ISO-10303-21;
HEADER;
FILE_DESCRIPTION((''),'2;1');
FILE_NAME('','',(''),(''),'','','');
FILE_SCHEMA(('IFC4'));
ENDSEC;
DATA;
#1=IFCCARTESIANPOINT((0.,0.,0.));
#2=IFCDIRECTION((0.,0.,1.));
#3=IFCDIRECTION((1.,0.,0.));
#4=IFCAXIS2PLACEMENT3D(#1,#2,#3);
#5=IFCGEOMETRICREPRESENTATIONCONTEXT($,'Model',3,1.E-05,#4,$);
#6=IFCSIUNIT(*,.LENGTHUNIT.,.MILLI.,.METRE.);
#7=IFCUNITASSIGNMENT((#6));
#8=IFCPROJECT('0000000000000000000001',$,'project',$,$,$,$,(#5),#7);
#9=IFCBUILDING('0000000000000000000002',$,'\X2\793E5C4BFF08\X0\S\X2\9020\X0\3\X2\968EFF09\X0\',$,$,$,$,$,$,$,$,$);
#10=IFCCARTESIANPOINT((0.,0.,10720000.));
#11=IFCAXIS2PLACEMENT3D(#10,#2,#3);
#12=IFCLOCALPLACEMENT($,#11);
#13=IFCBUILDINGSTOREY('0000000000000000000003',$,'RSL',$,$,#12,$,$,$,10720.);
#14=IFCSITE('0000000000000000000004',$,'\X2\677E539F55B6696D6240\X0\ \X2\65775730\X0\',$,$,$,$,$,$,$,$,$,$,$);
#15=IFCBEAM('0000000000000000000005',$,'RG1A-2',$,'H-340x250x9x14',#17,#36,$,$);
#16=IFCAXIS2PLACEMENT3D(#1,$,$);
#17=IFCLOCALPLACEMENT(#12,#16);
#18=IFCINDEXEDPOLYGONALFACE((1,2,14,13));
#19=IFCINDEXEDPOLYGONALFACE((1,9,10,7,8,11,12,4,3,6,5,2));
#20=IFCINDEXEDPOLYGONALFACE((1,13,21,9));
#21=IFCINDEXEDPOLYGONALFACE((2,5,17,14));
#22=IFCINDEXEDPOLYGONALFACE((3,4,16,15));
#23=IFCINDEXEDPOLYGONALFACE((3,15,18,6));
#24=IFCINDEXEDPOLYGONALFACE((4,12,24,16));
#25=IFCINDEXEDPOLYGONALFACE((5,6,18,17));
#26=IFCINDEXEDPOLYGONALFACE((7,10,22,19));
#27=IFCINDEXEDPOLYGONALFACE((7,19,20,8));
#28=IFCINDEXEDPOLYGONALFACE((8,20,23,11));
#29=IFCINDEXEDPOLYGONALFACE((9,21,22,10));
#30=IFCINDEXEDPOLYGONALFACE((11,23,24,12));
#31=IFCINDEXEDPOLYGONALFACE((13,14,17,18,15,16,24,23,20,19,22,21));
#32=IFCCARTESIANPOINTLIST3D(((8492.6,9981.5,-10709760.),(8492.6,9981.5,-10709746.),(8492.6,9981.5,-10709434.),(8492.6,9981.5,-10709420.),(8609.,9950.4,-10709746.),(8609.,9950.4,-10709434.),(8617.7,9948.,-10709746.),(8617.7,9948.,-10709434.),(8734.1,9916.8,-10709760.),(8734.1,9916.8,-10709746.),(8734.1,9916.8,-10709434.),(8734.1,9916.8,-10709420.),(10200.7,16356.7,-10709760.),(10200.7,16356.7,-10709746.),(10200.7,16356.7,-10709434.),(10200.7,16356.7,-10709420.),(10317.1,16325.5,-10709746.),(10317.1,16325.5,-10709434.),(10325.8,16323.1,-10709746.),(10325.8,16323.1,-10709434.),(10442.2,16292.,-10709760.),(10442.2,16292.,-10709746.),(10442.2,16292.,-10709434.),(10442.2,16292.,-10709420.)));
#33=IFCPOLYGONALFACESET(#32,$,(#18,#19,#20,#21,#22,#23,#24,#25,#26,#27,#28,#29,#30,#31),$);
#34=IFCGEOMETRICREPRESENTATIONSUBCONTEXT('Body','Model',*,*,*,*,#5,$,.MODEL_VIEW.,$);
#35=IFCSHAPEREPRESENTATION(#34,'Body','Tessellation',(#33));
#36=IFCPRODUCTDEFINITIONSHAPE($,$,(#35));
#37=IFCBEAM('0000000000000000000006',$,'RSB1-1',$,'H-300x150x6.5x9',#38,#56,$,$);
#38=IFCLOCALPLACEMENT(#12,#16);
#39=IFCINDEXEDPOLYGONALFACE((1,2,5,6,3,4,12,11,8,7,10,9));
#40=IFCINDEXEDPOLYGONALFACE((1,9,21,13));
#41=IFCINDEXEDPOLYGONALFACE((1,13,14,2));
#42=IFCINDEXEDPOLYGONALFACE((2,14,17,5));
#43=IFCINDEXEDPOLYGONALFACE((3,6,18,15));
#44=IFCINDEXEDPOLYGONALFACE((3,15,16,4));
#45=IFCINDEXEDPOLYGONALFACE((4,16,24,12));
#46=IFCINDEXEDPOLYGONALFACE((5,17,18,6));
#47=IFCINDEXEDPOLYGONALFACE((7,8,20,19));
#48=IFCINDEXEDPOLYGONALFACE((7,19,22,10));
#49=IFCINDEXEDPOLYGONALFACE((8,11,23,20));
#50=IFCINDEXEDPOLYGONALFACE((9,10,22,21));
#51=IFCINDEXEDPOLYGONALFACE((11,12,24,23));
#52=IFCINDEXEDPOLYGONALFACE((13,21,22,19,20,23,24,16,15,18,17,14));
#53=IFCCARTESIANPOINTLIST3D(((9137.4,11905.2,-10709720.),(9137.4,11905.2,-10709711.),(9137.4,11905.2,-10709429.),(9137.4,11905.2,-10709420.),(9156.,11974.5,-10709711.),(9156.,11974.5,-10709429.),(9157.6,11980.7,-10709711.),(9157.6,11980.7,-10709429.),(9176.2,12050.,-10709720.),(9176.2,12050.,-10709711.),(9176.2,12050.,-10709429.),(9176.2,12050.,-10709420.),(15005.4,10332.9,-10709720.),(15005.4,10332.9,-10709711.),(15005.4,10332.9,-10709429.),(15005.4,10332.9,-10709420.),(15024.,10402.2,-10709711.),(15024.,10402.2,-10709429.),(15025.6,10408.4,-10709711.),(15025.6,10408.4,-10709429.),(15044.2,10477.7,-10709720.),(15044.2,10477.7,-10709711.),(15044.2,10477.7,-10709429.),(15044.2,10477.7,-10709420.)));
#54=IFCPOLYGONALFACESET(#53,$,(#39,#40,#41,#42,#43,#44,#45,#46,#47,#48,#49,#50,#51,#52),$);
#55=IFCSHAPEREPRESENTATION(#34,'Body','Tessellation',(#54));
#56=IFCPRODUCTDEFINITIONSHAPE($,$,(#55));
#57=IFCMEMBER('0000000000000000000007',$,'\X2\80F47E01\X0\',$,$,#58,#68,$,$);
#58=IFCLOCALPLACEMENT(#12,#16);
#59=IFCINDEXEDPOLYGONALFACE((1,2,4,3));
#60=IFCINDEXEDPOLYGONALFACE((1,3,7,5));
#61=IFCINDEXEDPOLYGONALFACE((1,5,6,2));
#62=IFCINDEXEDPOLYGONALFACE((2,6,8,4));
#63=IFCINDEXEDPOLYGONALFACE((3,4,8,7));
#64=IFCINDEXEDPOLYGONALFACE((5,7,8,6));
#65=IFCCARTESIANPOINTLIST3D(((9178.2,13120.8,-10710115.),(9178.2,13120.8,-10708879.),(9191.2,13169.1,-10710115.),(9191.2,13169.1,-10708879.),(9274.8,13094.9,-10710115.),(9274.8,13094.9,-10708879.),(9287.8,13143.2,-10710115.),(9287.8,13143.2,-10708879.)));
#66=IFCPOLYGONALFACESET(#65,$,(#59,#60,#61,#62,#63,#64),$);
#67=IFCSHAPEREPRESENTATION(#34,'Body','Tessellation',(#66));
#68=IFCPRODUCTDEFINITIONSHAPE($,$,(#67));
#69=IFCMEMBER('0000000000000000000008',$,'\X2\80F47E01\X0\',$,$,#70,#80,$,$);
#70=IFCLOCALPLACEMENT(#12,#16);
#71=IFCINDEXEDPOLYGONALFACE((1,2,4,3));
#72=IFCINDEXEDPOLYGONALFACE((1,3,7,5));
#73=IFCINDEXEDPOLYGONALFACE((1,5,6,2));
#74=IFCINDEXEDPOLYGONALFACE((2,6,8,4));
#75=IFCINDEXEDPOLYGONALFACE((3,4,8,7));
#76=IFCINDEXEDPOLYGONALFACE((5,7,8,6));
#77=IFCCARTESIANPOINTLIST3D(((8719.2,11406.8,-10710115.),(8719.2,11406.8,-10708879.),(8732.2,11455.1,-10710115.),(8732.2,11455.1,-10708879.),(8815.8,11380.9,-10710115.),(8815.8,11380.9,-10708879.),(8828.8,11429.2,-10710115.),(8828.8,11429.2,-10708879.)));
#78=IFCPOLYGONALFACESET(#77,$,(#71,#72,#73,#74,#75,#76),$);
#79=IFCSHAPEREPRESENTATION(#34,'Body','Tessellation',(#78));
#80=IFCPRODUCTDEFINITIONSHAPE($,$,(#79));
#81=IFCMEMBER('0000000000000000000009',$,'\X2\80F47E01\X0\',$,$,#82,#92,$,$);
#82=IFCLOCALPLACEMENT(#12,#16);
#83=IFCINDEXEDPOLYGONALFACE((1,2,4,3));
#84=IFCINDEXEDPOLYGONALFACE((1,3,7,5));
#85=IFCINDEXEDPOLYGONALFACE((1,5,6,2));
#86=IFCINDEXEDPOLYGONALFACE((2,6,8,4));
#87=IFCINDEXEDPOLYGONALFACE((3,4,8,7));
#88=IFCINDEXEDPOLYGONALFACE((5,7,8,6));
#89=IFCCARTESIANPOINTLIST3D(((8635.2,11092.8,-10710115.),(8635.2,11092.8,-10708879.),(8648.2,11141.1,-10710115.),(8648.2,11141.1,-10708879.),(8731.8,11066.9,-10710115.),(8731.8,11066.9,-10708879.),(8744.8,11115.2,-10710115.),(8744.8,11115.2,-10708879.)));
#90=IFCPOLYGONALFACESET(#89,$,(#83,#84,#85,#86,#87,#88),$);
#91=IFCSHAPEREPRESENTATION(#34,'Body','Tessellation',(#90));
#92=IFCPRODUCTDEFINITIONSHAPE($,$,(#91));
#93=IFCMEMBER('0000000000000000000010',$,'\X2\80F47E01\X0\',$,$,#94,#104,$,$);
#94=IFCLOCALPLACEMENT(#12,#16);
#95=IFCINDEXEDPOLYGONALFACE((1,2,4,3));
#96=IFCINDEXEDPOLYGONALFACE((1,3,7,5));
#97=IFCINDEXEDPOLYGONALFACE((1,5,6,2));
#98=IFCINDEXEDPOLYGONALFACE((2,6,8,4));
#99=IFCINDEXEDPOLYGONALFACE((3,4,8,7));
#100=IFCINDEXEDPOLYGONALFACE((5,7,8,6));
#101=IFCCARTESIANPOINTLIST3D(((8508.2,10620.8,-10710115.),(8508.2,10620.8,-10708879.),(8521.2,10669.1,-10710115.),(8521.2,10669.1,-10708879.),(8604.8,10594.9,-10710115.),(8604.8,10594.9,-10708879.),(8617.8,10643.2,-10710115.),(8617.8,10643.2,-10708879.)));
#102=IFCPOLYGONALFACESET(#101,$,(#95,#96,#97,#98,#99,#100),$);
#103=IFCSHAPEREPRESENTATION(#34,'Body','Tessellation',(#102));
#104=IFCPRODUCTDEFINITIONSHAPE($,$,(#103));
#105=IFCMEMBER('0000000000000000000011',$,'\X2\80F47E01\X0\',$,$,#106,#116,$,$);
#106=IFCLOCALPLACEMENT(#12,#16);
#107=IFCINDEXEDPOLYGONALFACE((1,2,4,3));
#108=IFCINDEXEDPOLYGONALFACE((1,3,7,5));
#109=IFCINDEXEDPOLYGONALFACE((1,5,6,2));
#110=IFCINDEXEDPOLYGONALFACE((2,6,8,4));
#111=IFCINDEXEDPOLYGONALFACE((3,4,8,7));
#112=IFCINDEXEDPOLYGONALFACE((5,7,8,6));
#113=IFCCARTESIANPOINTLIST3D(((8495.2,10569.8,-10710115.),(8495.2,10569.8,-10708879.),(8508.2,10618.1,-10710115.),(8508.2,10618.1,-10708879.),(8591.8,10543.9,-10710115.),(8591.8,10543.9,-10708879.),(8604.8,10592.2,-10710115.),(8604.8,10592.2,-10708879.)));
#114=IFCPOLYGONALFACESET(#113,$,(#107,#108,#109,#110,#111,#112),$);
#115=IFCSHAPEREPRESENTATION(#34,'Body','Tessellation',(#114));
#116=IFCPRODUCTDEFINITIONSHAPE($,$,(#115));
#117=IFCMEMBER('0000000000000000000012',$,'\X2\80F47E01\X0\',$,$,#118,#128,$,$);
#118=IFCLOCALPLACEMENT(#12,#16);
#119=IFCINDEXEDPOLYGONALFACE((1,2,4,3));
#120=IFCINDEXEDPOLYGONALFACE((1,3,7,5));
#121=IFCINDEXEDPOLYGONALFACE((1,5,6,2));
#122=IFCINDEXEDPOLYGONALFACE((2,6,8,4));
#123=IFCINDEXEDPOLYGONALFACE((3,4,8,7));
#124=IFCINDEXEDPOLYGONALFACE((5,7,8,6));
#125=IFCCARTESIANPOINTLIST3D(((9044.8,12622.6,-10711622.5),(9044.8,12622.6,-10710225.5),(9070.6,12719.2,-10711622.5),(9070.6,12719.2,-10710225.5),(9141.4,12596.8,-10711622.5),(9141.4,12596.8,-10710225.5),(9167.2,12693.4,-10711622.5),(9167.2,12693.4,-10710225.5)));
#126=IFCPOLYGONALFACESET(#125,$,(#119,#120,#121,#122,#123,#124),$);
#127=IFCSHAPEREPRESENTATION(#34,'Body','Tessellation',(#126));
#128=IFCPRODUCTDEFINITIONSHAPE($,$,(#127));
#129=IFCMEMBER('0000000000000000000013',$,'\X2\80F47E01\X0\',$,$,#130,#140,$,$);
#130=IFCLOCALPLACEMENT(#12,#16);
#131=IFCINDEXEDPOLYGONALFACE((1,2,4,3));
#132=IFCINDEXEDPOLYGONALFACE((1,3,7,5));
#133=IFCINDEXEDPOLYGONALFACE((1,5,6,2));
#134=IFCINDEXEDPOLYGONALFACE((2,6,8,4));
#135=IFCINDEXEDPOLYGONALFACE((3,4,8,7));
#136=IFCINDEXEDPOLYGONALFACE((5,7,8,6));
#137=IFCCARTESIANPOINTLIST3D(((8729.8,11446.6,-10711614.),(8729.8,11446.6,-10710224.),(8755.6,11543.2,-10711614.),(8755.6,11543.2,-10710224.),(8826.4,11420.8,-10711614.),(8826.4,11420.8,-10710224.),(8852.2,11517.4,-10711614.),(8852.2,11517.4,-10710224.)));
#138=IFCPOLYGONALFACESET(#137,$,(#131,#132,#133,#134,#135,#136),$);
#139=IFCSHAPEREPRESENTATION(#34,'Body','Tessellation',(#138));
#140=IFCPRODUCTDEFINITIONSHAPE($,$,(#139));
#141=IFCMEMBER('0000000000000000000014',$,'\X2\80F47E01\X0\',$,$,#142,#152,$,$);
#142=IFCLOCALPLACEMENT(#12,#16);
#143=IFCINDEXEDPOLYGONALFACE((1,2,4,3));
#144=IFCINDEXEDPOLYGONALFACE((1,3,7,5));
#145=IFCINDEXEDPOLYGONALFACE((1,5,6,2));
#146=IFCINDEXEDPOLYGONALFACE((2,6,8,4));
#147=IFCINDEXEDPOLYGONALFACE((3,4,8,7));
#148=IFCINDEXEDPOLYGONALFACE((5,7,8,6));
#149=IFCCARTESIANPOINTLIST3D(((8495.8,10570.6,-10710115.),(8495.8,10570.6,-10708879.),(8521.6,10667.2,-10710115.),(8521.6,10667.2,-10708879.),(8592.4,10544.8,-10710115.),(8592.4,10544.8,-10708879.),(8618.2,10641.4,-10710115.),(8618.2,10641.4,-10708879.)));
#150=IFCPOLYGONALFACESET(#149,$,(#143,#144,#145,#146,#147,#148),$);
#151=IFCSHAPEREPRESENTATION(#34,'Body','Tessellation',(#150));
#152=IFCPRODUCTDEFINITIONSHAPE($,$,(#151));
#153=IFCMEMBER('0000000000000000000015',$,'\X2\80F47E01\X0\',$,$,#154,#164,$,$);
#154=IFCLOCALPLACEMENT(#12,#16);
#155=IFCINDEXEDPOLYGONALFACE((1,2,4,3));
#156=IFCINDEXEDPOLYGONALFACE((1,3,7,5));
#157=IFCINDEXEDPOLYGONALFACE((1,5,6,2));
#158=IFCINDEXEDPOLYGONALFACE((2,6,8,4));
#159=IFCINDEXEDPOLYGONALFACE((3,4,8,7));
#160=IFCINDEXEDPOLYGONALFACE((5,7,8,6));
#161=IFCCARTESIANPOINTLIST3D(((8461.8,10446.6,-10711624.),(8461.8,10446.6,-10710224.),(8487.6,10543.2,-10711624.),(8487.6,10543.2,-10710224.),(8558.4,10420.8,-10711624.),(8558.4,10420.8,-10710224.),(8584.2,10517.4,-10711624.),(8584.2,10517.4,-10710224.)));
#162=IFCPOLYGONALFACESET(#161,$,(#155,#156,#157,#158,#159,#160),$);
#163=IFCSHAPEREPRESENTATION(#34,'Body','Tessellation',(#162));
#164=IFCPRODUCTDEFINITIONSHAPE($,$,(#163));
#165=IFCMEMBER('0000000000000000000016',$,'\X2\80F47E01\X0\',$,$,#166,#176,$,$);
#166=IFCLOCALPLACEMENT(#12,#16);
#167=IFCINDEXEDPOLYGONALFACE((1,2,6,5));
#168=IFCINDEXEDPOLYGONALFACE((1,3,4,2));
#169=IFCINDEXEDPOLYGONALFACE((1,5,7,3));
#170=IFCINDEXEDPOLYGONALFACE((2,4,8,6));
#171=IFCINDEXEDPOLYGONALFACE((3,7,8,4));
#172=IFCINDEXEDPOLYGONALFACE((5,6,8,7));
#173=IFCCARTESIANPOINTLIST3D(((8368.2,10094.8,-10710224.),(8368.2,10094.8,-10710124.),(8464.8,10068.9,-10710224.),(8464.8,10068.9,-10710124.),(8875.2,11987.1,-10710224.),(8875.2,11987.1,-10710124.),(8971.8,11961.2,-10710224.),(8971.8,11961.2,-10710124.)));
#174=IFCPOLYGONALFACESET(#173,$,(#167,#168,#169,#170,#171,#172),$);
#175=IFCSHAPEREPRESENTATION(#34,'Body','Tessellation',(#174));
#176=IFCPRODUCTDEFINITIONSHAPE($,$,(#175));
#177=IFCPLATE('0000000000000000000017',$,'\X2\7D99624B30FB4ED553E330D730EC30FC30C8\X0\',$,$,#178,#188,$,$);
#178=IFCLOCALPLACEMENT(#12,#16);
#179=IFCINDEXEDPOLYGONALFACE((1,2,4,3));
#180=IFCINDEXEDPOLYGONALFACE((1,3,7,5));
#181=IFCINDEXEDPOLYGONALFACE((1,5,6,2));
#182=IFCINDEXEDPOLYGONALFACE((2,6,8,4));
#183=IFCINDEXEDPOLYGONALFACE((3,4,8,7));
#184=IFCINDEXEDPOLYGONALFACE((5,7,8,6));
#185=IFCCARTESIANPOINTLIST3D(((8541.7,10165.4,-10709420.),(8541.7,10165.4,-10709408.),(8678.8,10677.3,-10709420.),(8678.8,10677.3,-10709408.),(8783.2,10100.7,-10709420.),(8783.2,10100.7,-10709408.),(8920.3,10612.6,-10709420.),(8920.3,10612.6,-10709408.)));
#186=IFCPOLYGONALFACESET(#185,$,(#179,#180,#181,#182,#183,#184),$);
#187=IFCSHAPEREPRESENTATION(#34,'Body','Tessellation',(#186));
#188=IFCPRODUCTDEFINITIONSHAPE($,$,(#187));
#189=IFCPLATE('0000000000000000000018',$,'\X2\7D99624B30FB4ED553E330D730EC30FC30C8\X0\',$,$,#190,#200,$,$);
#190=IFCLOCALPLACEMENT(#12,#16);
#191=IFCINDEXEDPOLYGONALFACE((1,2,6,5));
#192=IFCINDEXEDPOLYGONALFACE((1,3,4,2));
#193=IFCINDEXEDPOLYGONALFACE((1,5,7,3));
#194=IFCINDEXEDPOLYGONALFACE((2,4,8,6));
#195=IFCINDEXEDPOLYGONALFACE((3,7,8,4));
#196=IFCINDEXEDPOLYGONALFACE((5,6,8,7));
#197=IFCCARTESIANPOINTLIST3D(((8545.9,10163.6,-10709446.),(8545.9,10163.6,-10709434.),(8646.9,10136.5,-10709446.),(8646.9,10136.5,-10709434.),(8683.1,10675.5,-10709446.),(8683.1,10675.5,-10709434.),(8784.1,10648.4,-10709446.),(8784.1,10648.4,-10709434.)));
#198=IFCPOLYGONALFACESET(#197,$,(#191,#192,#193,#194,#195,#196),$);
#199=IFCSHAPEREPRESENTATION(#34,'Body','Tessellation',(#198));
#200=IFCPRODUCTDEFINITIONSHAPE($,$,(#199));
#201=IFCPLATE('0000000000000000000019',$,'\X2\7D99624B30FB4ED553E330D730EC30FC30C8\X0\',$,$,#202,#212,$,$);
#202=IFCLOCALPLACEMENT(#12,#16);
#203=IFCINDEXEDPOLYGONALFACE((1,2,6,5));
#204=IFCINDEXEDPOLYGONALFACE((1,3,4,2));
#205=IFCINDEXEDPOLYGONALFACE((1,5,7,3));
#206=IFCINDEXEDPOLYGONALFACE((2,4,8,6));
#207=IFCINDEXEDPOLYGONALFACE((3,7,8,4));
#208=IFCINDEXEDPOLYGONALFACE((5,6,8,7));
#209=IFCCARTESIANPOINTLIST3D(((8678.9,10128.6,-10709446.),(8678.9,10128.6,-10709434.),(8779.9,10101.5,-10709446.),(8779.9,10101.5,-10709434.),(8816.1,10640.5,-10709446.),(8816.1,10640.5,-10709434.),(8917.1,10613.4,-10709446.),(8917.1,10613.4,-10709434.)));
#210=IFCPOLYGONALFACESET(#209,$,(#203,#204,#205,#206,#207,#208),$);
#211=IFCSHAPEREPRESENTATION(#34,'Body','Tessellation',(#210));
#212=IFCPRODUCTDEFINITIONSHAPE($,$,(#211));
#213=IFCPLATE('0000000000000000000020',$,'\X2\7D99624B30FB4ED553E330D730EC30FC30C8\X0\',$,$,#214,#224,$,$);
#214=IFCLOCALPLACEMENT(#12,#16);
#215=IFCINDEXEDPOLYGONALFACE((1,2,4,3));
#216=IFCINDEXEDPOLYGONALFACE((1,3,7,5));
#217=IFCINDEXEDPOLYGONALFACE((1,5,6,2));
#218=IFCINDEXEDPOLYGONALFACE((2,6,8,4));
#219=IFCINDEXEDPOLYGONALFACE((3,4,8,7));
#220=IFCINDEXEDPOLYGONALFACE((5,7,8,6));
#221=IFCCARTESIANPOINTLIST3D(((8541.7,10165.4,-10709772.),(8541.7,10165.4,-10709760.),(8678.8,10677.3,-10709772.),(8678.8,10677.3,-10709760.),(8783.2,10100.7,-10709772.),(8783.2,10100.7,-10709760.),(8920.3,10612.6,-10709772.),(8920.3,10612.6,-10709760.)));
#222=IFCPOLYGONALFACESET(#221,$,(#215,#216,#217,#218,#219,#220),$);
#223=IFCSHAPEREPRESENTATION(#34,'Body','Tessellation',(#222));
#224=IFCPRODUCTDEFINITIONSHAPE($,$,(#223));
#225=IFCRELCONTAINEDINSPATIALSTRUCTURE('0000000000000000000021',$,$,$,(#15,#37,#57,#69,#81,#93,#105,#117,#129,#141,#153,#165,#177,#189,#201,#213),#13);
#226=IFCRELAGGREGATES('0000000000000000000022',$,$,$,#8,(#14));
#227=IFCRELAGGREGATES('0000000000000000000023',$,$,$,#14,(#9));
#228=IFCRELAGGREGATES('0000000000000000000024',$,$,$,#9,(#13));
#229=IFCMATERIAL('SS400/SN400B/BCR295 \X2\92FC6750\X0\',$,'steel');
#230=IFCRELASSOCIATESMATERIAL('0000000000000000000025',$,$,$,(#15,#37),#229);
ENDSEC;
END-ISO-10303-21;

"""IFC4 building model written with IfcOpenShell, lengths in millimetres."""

from ifc_helpers import new_model, si_unit, frame, origin, origin_with_axes, place, context, subcontext, project, spatial, rectangle, i_section, extrude, material, element, save


model = new_model("IFC4")

# Units and contexts
model_context = context("Model", 3, precision=1e-05, world=origin_with_axes())
body_context = subcontext(model_context, "Body", "Model", "MODEL_VIEW")
ifc_project = project(units=[si_unit("LENGTHUNIT", "METRE", prefix="MILLI")], contexts=[model_context])

# Site, building, storey
site = spatial("IfcSite", under=ifc_project, Name="松原営業所 敷地")
building = spatial("IfcBuilding", under=site, Name="社屋（S造3階）")
storey_placement = place(None, frame((0.0, 0.0, 10720000.0), z_axis=(0.0, 0.0, 1.0), x_axis=(1.0, 0.0, 0.0)))
storey = spatial("IfcBuildingStorey", under=building, at=storey_placement, Name="RSL", Elevation=10720.0)

# Beams
ifc_material = material(Name="SS400/SN400B/BCR295 鋼材", Category="steel")
beam_1_placement = place(storey_placement, frame((8613.3, 9949.2, -10709420.0), z_axis=(0.258812, 0.965928, 0.0), x_axis=(-0.965928, 0.258812, 0.0)))
element("IfcBeam", 1, at=beam_1_placement, inside=storey, material=ifc_material, Name="RG1A-2", ObjectType="H-340x250x9x14", context=body_context, shape_type="SweptSolid", body=[
    extrude(i_section(OverallWidth=250.0, OverallDepth=340.0, WebThickness=9.0, FlangeThickness=14.0), frame((0.0, -170.0, 0.0)), (0.0, 0.0, 1.0), 6600.0),
])
beam_2_placement = place(storey_placement, frame((9156.8, 11977.6, -10709420.0), z_axis=(0.965927, -0.258815, 0.0), x_axis=(0.258815, 0.965927, 0.0)))
element("IfcBeam", 2, at=beam_2_placement, inside=storey, material=ifc_material, Name="RSB1-1", ObjectType="H-300x150x6.5x9", context=body_context, shape_type="SweptSolid", body=[
    extrude(i_section(OverallWidth=150.0, OverallDepth=300.0, WebThickness=6.5, FlangeThickness=9.0), frame((0.0, -150.0, 0.0)), (0.0, 0.0, 1.0), 6075.0),
])

# Members
for number, where, z_axis, x_axis, name in (
    (3, (9239.5, 13156.1, -10709497.0), (-0.258819, -0.965926, 0.0), (0.965926, -0.258819, 0.0), "胴縁"),
    (4, (8780.5, 11442.1, -10709497.0), (-0.258819, -0.965926, 0.0), (0.965926, -0.258819, 0.0), "胴縁"),
    (5, (8696.5, 11128.1, -10709497.0), (-0.258819, -0.965926, 0.0), (0.965926, -0.258819, 0.0), "胴縁"),
    (6, (8569.5, 10656.1, -10709497.0), (-0.258819, -0.965926, 0.0), (0.965926, -0.258819, 0.0), "胴縁"),
    (7, (8556.5, 10605.1, -10709497.0), (-0.258819, -0.965926, 0.0), (0.965926, -0.258819, 0.0), "胴縁"),
):
    element("IfcMember", number, at=place(storey_placement, frame(where, z_axis=z_axis, x_axis=x_axis)), inside=storey, Name=name, context=body_context, shape_type="SweptSolid", body=[
        extrude(rectangle(XDim=100.0, YDim=1236.0), origin(), (0.0, 0.0, 1.0), 50.0),
    ])
member_1_placement = place(storey_placement, frame((9118.9, 12706.3, -10710924.0), z_axis=(-0.258819, -0.965926, 0.0), x_axis=(0.965926, -0.258819, 0.0)))
element("IfcMember", 8, at=member_1_placement, inside=storey, Name="胴縁", context=body_context, shape_type="SweptSolid", body=[
    extrude(rectangle(XDim=100.0, YDim=1397.0), origin(), (0.0, 0.0, 1.0), 100.0),
])
member_2_placement = place(storey_placement, frame((8803.9, 11530.3, -10710919.0), z_axis=(-0.258819, -0.965926, 0.0), x_axis=(0.965926, -0.258819, 0.0)))
element("IfcMember", 9, at=member_2_placement, inside=storey, Name="胴縁", context=body_context, shape_type="SweptSolid", body=[
    extrude(rectangle(XDim=100.0, YDim=1390.0), origin(), (0.0, 0.0, 1.0), 100.0),
])
member_3_placement = place(storey_placement, frame((8569.9, 10654.3, -10709497.0), z_axis=(-0.258819, -0.965926, 0.0), x_axis=(0.965926, -0.258819, 0.0)))
element("IfcMember", 10, at=member_3_placement, inside=storey, Name="胴縁", context=body_context, shape_type="SweptSolid", body=[
    extrude(rectangle(XDim=100.0, YDim=1236.0), origin(), (0.0, 0.0, 1.0), 100.0),
])
member_4_placement = place(storey_placement, frame((8535.9, 10530.3, -10710924.0), z_axis=(-0.258819, -0.965926, 0.0), x_axis=(0.965926, -0.258819, 0.0)))
element("IfcMember", 11, at=member_4_placement, inside=storey, Name="胴縁", context=body_context, shape_type="SweptSolid", body=[
    extrude(rectangle(XDim=100.0, YDim=1400.0), origin(), (0.0, 0.0, 1.0), 100.0),
])
member_5_placement = place(storey_placement, frame((8923.5, 11974.1, -10710174.0), z_axis=(-0.258819, -0.965926, 0.0), x_axis=(0.965926, -0.258819, 0.0)))
element("IfcMember", 12, at=member_5_placement, inside=storey, Name="胴縁", context=body_context, shape_type="SweptSolid", body=[
    extrude(rectangle(XDim=100.0, YDim=100.0), origin(), (0.0, 0.0, 1.0), 1959.0),
])

# Plates
plate_1_placement = place(storey_placement, frame((8662.4, 10133.0, -10709414.0), z_axis=(0.258819, 0.965926, 0.0), x_axis=(-0.965926, 0.258819, 0.0)))
element("IfcPlate", 13, at=plate_1_placement, inside=storey, Name="継手・仕口プレート", context=body_context, shape_type="SweptSolid", body=[
    extrude(rectangle(XDim=250.0, YDim=12.0), origin(), (0.0, 0.0, 1.0), 530.0),
])
for number, where, z_axis, x_axis, name in (
    (14, (8596.4, 10150.0, -10709440.0), (0.258819, 0.965926, 0.0), (-0.965926, 0.258819, 0.0), "継手・仕口プレート"),
    (15, (8729.4, 10115.0, -10709440.0), (0.258819, 0.965926, 0.0), (-0.965926, 0.258819, 0.0), "継手・仕口プレート"),
):
    element("IfcPlate", number, at=place(storey_placement, frame(where, z_axis=z_axis, x_axis=x_axis)), inside=storey, Name=name, context=body_context, shape_type="SweptSolid", body=[
        extrude(rectangle(XDim=104.5, YDim=12.0), origin(), (0.0, 0.0, 1.0), 530.0),
    ])
plate_2_placement = place(storey_placement, frame((8662.4, 10133.0, -10709766.0), z_axis=(0.258819, 0.965926, 0.0), x_axis=(-0.965926, 0.258819, 0.0)))
element("IfcPlate", 16, at=plate_2_placement, inside=storey, Name="継手・仕口プレート", context=body_context, shape_type="SweptSolid", body=[
    extrude(rectangle(XDim=250.0, YDim=12.0), origin(), (0.0, 0.0, 1.0), 530.0),
])

save(model, "model.ifc")
